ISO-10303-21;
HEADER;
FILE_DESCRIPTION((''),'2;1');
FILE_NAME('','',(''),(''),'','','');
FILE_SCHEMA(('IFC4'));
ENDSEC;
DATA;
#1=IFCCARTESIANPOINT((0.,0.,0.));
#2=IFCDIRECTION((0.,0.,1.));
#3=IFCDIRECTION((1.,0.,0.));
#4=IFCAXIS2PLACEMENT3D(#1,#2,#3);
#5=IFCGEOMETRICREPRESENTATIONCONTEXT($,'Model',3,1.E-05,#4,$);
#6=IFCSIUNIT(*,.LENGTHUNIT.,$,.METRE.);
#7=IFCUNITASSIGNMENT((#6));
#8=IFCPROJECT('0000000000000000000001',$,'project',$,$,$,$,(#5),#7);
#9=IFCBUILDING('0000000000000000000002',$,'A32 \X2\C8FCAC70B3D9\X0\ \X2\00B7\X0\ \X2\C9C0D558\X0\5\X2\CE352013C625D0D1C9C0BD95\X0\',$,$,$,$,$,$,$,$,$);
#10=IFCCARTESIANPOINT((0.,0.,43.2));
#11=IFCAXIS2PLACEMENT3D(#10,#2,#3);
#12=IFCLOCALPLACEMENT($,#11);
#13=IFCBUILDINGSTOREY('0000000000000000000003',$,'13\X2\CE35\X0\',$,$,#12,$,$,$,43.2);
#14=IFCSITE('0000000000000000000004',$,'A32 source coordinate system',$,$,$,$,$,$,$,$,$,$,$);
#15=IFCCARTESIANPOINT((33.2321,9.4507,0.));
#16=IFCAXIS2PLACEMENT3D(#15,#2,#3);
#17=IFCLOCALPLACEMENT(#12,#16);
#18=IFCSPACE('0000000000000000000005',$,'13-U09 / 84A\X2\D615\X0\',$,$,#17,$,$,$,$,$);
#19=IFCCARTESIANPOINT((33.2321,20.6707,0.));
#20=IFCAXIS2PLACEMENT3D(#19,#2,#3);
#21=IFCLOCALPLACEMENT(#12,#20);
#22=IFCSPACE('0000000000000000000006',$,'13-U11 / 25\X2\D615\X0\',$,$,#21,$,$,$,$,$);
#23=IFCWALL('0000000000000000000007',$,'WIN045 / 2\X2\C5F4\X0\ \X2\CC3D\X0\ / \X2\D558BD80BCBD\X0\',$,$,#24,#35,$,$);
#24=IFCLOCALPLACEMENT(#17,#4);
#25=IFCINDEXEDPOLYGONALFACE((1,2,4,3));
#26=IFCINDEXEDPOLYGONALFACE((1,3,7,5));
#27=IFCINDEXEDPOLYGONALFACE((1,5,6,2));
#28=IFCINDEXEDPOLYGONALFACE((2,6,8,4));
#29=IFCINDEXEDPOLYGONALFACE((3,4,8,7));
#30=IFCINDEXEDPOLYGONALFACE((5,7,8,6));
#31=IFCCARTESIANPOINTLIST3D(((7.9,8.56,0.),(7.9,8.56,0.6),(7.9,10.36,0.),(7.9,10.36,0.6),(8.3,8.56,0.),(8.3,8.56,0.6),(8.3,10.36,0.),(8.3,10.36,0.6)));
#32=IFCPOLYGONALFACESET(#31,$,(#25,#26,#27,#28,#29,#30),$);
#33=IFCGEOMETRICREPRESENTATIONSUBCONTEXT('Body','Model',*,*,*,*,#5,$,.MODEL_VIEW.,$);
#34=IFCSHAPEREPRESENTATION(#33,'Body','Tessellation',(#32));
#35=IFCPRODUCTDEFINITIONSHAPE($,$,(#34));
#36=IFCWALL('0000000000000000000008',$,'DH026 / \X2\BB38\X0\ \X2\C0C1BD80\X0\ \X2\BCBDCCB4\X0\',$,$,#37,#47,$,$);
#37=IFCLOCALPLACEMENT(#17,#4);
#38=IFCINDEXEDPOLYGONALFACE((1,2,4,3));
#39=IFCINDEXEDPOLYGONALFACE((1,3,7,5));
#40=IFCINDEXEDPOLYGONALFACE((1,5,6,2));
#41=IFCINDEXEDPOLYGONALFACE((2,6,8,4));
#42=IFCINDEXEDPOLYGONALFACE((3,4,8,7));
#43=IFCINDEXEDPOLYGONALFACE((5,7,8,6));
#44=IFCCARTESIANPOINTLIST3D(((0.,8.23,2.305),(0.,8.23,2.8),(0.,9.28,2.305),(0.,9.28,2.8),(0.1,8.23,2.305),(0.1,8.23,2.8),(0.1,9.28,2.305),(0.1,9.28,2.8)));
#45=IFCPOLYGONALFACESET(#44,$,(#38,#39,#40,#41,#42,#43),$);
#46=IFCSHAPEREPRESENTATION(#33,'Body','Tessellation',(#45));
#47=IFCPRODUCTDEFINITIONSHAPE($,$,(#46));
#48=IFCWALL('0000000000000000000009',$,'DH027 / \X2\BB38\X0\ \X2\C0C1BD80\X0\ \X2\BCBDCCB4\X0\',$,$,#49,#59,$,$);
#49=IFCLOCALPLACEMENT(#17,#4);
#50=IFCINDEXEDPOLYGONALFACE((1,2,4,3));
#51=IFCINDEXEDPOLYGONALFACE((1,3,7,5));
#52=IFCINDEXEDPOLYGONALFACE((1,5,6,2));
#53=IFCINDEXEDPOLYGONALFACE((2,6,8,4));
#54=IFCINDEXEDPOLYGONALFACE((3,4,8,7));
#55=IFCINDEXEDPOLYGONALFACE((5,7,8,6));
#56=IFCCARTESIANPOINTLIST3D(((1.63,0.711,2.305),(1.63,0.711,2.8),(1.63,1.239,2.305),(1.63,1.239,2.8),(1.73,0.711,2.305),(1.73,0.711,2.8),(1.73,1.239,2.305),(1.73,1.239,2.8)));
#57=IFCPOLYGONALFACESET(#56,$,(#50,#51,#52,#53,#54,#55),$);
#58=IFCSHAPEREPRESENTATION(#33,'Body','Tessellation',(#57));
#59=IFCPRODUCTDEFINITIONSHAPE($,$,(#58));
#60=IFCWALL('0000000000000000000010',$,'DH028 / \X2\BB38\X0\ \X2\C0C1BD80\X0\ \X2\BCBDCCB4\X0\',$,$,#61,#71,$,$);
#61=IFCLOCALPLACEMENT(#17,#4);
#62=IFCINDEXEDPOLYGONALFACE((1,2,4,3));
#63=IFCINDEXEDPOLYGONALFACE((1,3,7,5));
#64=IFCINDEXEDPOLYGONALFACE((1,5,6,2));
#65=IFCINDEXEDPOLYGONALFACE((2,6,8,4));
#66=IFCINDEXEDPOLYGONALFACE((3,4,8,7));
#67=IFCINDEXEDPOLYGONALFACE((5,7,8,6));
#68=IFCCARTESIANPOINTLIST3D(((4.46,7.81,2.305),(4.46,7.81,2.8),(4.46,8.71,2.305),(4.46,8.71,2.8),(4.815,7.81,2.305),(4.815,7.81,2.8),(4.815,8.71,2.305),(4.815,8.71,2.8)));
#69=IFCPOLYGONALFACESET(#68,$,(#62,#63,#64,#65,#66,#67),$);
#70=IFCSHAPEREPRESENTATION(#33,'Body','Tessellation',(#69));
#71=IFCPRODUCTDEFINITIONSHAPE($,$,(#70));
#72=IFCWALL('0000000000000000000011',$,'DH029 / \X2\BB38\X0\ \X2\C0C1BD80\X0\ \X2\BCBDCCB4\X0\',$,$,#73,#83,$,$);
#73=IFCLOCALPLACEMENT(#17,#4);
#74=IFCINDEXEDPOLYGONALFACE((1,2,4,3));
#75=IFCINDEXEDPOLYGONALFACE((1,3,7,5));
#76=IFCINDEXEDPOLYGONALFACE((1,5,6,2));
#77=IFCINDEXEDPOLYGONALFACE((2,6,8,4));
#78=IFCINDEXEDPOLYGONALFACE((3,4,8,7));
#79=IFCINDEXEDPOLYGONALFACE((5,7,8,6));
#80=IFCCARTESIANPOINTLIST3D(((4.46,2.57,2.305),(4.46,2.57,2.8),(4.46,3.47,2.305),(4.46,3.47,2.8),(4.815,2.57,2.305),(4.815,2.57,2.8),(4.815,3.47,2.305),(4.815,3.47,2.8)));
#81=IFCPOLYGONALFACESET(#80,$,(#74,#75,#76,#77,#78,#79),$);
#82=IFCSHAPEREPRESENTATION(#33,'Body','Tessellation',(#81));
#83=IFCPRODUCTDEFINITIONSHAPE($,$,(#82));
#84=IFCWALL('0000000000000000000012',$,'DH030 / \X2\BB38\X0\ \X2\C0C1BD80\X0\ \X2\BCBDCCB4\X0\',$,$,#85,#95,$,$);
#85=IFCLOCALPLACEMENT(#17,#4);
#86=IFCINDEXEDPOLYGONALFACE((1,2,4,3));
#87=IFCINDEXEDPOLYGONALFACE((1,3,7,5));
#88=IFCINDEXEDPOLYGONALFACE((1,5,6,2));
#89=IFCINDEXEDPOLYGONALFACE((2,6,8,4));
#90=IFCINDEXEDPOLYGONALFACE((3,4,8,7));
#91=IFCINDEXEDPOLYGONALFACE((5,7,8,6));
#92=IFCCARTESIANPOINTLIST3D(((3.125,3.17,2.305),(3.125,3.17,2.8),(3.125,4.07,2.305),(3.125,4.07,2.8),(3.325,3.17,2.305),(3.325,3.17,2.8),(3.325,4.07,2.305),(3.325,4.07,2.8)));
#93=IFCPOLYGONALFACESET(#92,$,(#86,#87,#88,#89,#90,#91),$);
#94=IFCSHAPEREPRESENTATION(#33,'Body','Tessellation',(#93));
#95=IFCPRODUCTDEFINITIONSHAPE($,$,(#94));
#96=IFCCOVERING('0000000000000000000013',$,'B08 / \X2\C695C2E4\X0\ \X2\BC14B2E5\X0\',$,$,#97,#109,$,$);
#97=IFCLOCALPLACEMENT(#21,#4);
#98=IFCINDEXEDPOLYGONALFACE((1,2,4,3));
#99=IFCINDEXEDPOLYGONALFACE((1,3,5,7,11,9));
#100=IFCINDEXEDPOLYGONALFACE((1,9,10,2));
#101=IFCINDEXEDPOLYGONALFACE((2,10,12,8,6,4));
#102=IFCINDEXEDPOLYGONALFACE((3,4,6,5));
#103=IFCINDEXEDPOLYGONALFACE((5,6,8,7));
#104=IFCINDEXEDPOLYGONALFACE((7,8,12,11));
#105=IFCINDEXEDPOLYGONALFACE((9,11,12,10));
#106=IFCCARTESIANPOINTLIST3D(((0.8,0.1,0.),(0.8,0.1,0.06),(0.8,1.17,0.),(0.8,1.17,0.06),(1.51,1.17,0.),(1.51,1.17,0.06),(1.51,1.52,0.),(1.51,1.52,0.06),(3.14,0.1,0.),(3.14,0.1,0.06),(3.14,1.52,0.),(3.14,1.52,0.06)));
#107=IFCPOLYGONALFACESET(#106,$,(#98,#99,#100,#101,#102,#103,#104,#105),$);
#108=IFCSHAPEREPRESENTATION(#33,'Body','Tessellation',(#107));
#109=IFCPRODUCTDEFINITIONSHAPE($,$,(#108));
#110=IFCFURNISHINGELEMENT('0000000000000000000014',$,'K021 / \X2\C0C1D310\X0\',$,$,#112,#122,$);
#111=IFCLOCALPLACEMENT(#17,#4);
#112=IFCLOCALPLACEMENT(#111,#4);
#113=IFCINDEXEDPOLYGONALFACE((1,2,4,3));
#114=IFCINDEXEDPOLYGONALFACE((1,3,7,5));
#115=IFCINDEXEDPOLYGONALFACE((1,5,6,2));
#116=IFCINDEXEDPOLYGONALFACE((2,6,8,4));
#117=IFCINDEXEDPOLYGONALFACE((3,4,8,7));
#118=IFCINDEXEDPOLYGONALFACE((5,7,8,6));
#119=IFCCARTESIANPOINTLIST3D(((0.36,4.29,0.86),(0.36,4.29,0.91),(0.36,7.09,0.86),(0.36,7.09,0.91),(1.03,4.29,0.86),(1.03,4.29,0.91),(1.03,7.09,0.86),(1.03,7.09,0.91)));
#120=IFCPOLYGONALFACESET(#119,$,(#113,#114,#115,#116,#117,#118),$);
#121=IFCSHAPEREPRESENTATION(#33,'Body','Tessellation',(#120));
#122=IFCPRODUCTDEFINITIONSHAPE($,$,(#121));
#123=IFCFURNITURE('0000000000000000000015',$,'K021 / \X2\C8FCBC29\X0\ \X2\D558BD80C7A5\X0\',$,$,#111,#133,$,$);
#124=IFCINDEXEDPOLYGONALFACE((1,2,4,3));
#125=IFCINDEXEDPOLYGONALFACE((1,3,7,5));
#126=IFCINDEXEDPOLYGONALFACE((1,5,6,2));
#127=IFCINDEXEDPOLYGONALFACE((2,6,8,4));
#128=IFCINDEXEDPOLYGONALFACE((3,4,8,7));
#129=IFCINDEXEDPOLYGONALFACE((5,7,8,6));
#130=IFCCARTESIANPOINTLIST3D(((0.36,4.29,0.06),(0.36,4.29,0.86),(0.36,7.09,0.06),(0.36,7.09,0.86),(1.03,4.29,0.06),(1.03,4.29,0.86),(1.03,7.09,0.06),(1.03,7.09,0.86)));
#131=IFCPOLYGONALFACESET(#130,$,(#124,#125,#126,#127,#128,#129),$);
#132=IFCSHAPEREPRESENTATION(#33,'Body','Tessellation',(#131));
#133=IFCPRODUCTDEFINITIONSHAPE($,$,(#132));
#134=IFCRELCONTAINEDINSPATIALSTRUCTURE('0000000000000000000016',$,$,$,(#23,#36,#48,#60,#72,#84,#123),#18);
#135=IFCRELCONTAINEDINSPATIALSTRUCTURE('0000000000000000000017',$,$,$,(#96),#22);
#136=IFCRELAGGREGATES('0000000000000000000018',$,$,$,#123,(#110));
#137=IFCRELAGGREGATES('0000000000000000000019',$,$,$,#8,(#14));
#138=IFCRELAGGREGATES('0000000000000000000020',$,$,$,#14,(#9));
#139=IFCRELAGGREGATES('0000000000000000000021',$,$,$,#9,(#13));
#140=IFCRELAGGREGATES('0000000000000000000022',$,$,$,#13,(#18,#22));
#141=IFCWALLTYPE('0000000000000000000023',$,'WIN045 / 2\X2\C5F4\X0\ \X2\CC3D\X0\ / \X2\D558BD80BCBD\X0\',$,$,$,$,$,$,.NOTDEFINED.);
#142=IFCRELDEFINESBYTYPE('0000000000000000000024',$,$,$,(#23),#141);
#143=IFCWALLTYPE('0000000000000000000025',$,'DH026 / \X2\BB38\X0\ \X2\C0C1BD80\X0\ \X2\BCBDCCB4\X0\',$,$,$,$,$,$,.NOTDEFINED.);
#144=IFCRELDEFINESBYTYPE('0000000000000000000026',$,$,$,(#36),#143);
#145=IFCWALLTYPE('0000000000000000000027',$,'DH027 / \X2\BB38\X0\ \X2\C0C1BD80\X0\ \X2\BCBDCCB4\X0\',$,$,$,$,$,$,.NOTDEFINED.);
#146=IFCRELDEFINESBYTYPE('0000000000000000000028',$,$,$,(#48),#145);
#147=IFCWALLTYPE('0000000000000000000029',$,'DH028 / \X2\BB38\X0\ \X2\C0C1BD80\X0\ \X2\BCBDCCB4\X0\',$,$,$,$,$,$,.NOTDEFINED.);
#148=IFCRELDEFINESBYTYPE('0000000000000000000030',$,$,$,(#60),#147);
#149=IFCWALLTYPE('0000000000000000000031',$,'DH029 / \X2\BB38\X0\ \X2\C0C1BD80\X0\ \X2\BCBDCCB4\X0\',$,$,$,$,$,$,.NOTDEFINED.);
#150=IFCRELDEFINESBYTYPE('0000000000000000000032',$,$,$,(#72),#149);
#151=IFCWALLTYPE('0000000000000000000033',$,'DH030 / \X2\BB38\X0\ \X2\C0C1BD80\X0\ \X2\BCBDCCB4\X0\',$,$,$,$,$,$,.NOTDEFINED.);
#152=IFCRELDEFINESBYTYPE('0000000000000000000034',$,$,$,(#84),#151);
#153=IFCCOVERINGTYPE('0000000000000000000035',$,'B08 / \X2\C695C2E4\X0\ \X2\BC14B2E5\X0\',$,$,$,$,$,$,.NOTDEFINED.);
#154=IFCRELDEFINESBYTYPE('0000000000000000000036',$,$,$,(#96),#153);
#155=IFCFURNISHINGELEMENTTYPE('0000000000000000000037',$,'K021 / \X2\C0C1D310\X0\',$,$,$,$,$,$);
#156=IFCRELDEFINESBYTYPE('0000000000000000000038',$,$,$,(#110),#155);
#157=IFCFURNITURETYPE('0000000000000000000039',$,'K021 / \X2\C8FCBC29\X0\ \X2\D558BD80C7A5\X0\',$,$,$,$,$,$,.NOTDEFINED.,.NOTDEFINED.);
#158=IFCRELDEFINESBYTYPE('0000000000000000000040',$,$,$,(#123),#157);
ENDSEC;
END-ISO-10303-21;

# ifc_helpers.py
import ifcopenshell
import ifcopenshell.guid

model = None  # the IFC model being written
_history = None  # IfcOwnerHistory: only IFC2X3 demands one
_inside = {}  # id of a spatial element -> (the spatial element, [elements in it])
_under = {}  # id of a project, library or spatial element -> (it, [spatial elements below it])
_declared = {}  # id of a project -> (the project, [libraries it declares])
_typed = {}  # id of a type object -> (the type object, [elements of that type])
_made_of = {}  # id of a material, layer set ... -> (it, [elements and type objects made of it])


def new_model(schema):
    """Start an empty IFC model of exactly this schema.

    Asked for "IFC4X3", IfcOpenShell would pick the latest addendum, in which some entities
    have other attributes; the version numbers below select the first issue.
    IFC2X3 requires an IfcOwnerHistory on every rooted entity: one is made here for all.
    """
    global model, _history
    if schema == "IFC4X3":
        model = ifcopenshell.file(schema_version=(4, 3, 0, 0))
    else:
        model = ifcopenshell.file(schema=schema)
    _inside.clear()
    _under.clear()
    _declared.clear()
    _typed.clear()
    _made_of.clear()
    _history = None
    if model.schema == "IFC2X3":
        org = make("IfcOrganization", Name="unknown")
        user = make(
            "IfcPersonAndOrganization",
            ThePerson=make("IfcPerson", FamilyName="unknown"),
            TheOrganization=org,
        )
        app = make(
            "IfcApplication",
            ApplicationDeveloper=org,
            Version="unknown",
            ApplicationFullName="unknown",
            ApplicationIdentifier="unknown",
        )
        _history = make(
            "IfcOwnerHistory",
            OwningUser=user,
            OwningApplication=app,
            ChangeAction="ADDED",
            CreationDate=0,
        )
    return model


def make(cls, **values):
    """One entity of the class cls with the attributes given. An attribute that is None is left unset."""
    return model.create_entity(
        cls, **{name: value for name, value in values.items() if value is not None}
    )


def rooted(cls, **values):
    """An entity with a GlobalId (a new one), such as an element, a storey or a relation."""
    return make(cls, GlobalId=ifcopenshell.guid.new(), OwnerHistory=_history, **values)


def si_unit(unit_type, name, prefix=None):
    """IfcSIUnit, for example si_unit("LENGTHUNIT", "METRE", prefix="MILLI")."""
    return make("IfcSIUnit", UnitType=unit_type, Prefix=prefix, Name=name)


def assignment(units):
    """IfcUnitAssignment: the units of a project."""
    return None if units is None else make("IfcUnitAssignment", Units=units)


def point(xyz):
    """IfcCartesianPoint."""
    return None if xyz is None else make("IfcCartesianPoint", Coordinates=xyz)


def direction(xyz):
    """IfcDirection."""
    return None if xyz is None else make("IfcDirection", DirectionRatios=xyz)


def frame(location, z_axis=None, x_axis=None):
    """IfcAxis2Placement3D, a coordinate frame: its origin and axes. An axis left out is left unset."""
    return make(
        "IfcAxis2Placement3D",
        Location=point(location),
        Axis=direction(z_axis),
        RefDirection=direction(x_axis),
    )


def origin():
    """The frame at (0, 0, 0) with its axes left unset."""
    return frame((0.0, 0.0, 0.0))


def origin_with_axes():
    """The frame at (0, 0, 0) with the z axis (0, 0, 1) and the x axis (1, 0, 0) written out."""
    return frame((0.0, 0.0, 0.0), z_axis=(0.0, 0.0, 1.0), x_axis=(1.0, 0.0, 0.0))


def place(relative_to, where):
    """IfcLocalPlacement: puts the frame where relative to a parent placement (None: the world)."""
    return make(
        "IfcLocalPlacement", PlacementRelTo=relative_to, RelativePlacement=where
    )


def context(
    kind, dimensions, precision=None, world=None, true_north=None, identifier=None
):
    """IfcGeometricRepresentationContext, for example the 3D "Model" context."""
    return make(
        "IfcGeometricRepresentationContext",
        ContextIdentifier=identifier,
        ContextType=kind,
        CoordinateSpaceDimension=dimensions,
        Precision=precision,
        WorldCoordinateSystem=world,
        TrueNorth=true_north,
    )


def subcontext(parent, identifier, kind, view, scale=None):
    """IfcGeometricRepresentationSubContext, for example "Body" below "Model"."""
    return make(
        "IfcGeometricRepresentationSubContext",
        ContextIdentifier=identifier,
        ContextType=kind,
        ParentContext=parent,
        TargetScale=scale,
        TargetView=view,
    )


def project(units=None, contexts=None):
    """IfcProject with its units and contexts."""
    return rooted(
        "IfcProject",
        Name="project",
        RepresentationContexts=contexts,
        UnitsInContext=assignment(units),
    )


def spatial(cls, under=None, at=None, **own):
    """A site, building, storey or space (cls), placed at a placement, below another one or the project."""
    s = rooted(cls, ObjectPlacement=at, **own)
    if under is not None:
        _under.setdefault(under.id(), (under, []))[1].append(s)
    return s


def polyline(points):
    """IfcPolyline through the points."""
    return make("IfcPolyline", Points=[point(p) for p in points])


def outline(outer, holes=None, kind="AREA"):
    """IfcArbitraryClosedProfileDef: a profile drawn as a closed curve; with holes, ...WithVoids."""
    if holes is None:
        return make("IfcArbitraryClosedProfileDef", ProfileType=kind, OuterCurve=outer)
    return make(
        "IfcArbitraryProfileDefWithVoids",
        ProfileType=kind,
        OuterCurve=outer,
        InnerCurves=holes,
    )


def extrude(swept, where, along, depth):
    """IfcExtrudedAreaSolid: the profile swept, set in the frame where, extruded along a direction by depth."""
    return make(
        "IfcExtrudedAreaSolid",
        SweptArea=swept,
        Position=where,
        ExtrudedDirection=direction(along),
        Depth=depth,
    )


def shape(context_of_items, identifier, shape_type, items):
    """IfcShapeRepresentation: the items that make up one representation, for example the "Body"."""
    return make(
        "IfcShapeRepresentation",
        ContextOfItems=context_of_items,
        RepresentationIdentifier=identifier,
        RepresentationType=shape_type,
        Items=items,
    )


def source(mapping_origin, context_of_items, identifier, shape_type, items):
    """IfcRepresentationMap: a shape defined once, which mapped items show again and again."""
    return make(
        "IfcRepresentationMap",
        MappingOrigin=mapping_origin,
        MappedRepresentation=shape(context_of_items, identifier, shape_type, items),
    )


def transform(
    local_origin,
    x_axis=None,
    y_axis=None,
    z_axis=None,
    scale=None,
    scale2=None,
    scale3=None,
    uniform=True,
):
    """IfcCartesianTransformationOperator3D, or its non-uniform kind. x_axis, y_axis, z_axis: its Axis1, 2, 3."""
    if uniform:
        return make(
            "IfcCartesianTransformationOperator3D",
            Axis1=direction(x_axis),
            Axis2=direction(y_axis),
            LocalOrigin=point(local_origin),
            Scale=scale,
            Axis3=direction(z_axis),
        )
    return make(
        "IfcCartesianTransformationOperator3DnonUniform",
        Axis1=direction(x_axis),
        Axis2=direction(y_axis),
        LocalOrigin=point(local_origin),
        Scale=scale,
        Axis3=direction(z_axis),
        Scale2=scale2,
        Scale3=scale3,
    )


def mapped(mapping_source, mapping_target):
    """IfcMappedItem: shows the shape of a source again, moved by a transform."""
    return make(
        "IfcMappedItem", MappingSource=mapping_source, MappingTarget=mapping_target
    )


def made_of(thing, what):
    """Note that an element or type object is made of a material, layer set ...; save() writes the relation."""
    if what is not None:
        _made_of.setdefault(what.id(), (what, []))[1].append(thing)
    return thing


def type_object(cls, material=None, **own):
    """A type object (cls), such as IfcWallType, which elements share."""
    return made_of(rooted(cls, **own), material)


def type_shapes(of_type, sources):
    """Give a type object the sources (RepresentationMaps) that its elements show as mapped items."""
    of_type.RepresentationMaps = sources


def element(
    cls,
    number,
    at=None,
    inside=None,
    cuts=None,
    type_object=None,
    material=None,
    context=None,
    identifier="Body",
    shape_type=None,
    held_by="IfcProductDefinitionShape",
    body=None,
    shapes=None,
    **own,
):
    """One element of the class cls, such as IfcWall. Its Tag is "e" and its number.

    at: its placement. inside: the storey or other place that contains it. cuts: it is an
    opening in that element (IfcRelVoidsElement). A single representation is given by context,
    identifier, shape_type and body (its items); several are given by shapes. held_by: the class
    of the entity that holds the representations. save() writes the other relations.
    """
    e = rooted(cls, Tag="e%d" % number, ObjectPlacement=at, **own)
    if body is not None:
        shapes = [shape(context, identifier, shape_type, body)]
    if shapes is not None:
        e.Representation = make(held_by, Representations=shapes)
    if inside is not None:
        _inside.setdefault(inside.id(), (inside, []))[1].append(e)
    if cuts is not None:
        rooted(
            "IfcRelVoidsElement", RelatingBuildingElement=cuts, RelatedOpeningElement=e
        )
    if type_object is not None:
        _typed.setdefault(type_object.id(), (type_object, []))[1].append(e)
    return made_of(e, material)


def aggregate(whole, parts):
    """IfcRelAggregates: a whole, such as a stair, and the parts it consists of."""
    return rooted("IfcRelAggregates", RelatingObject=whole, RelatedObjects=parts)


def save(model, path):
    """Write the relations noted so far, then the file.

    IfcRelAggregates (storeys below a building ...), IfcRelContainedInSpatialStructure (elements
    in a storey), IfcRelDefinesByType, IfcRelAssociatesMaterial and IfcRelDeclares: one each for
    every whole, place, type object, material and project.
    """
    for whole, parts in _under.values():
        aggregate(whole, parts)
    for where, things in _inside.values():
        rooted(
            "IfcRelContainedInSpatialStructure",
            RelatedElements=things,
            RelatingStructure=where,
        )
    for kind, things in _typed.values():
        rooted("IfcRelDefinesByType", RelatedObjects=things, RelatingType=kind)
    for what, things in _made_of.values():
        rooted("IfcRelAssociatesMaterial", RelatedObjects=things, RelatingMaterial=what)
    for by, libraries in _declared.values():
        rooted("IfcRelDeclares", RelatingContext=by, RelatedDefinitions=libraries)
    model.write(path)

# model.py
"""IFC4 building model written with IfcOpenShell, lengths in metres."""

from ifc_helpers import new_model, si_unit, frame, origin, origin_with_axes, place, context, subcontext, project, spatial, polyline, outline, extrude, source, transform, mapped, type_object, type_shapes, element, aggregate, save


model = new_model("IFC4")

# Units and contexts
model_context = context("Model", 3, precision=1e-05, world=origin_with_axes())
body_context = subcontext(model_context, "Body", "Model", "MODEL_VIEW")
ifc_project = project(units=[si_unit("LENGTHUNIT", "METRE")], contexts=[model_context])

# Site, building, storey, space
site = spatial("IfcSite", under=ifc_project, Name="A32 source coordinate system")
building = spatial("IfcBuilding", under=site, Name="A32 주거동 · 지하5층–옥탑지붕")
storey_placement = place(None, frame((0.0, 0.0, 43.2), z_axis=(0.0, 0.0, 1.0), x_axis=(1.0, 0.0, 0.0)))
storey = spatial("IfcBuildingStorey", under=building, at=storey_placement, Name="13층", Elevation=43.2)
space_1_placement = place(storey_placement, frame((33.2321, 9.4507, 0.0), z_axis=(0.0, 0.0, 1.0), x_axis=(1.0, 0.0, 0.0)))
space_1 = spatial("IfcSpace", under=storey, at=space_1_placement, Name="13-U09 / 84A형")

# Walls
wall_type_1 = type_object("IfcWallType", Name="WIN045 / 2열 창 / 하부벽", PredefinedType="NOTDEFINED")
shared_shape_1 = source(origin(), body_context, "Body", "SweptSolid", [
    extrude(outline(polyline([(7.9, 10.36), (8.3, 10.36), (8.3, 8.56), (7.9, 8.56), (7.9, 10.36)])), origin(), (0.0, 0.0, 1.0), 0.6),
])
type_shapes(wall_type_1, [shared_shape_1])
wall_1_placement = place(space_1_placement, origin_with_axes())
element("IfcWall", 1, at=wall_1_placement, inside=space_1, type_object=wall_type_1, Name="WIN045 / 2열 창 / 하부벽", context=body_context, shape_type="MappedRepresentation", body=[
    mapped(shared_shape_1, transform((0.0, 0.0, 0.0), scale=1.0)),
])
wall_type_2 = type_object("IfcWallType", Name="DH026 / 문 상부 벽체", PredefinedType="NOTDEFINED")
shared_shape_2 = source(origin(), body_context, "Body", "SweptSolid", [
    extrude(outline(polyline([(0.1, 9.28), (0.1, 8.23), (0.0, 8.23), (0.0, 9.28), (0.1, 9.28)])), frame((0.0, 0.0, 2.305)), (0.0, 0.0, 1.0), 0.495),
])
type_shapes(wall_type_2, [shared_shape_2])
wall_2_placement = place(space_1_placement, origin_with_axes())
element("IfcWall", 2, at=wall_2_placement, inside=space_1, type_object=wall_type_2, Name="DH026 / 문 상부 벽체", context=body_context, shape_type="MappedRepresentation", body=[
    mapped(shared_shape_2, transform((0.0, 0.0, 0.0), scale=1.0)),
])
wall_type_3 = type_object("IfcWallType", Name="DH027 / 문 상부 벽체", PredefinedType="NOTDEFINED")
shared_shape_3 = source(origin(), body_context, "Body", "SweptSolid", [
    extrude(outline(polyline([(1.63, 1.239), (1.73, 1.239), (1.73, 0.711), (1.63, 0.711), (1.63, 1.239)])), frame((0.0, 0.0, 2.305)), (0.0, 0.0, 1.0), 0.495),
])
type_shapes(wall_type_3, [shared_shape_3])
wall_3_placement = place(space_1_placement, origin_with_axes())
element("IfcWall", 3, at=wall_3_placement, inside=space_1, type_object=wall_type_3, Name="DH027 / 문 상부 벽체", context=body_context, shape_type="MappedRepresentation", body=[
    mapped(shared_shape_3, transform((0.0, 0.0, 0.0), scale=1.0)),
])
wall_type_4 = type_object("IfcWallType", Name="DH028 / 문 상부 벽체", PredefinedType="NOTDEFINED")
shared_shape_4 = source(origin(), body_context, "Body", "SweptSolid", [
    extrude(outline(polyline([(4.815, 8.71), (4.815, 7.81), (4.46, 7.81), (4.46, 8.71), (4.815, 8.71)])), frame((0.0, 0.0, 2.305)), (0.0, 0.0, 1.0), 0.495),
])
type_shapes(wall_type_4, [shared_shape_4])
wall_4_placement = place(space_1_placement, origin_with_axes())
element("IfcWall", 4, at=wall_4_placement, inside=space_1, type_object=wall_type_4, Name="DH028 / 문 상부 벽체", context=body_context, shape_type="MappedRepresentation", body=[
    mapped(shared_shape_4, transform((0.0, 0.0, 0.0), scale=1.0)),
])
wall_type_5 = type_object("IfcWallType", Name="DH029 / 문 상부 벽체", PredefinedType="NOTDEFINED")
shared_shape_5 = source(origin(), body_context, "Body", "SweptSolid", [
    extrude(outline(polyline([(4.815, 3.47), (4.815, 2.57), (4.46, 2.57), (4.46, 3.47), (4.815, 3.47)])), frame((0.0, 0.0, 2.305)), (0.0, 0.0, 1.0), 0.495),
])
type_shapes(wall_type_5, [shared_shape_5])
wall_5_placement = place(space_1_placement, origin_with_axes())
element("IfcWall", 5, at=wall_5_placement, inside=space_1, type_object=wall_type_5, Name="DH029 / 문 상부 벽체", context=body_context, shape_type="MappedRepresentation", body=[
    mapped(shared_shape_5, transform((0.0, 0.0, 0.0), scale=1.0)),
])
wall_type_6 = type_object("IfcWallType", Name="DH030 / 문 상부 벽체", PredefinedType="NOTDEFINED")
shared_shape_6 = source(origin(), body_context, "Body", "SweptSolid", [
    extrude(outline(polyline([(3.325, 4.07), (3.325, 3.17), (3.125, 3.17), (3.125, 4.07), (3.325, 4.07)])), frame((0.0, 0.0, 2.305)), (0.0, 0.0, 1.0), 0.495),
])
type_shapes(wall_type_6, [shared_shape_6])
wall_6_placement = place(space_1_placement, origin_with_axes())
element("IfcWall", 6, at=wall_6_placement, inside=space_1, type_object=wall_type_6, Name="DH030 / 문 상부 벽체", context=body_context, shape_type="MappedRepresentation", body=[
    mapped(shared_shape_6, transform((0.0, 0.0, 0.0), scale=1.0)),
])

# Shared definitions
space_2_placement = place(storey_placement, frame((33.2321, 20.6707, 0.0), z_axis=(0.0, 0.0, 1.0), x_axis=(1.0, 0.0, 0.0)))
space_2 = spatial("IfcSpace", under=storey, at=space_2_placement, Name="13-U11 / 25형")

# Covering
covering_type_1 = type_object("IfcCoveringType", Name="B08 / 욕실 바닥", PredefinedType="NOTDEFINED")
shared_shape_7 = source(origin(), body_context, "Body", "SweptSolid", [
    extrude(outline(polyline([(3.14, 0.1), (0.8, 0.1), (0.8, 1.17), (1.51, 1.17), (1.51, 1.52), (3.14, 1.52), (3.14, 0.1)])), origin(), (0.0, 0.0, 1.0), 0.06),
])
type_shapes(covering_type_1, [shared_shape_7])
covering_1_placement = place(space_2_placement, origin_with_axes())
element("IfcCovering", 7, at=covering_1_placement, inside=space_2, type_object=covering_type_1, Name="B08 / 욕실 바닥", context=body_context, shape_type="MappedRepresentation", body=[
    mapped(shared_shape_7, transform((0.0, 0.0, 0.0), scale=1.0)),
])

# Furnishing element
furnishing_element_type = type_object("IfcFurnishingElementType", Name="K021 / 상판")
shared_shape_8 = source(origin(), body_context, "Body", "SweptSolid", [
    extrude(outline(polyline([(0.36, 7.09), (1.03, 7.09), (1.03, 4.29), (0.36, 4.29), (0.36, 7.09)])), frame((0.0, 0.0, 0.86)), (0.0, 0.0, 1.0), 0.05),
])
type_shapes(furnishing_element_type, [shared_shape_8])
furniture_placement = place(space_1_placement, origin_with_axes())
furnishing_placement = place(furniture_placement, origin_with_axes())
furnishing = element("IfcFurnishingElement", 8, at=furnishing_placement, type_object=furnishing_element_type, Name="K021 / 상판", context=body_context, shape_type="MappedRepresentation", body=[
    mapped(shared_shape_8, transform((0.0, 0.0, 0.0), scale=1.0)),
])

# Furniture
furniture_type = type_object("IfcFurnitureType", Name="K021 / 주방 하부장", AssemblyPlace="NOTDEFINED", PredefinedType="NOTDEFINED")
shared_shape_9 = source(origin(), body_context, "Body", "SweptSolid", [
    extrude(outline(polyline([(0.36, 4.29), (0.36, 7.09), (1.03, 7.09), (1.03, 4.29), (0.36, 4.29)])), frame((0.0, 0.0, 0.06)), (0.0, 0.0, 1.0), 0.8),
])
type_shapes(furniture_type, [shared_shape_9])
furniture = element("IfcFurniture", 9, at=furniture_placement, inside=space_1, type_object=furniture_type, Name="K021 / 주방 하부장", context=body_context, shape_type="MappedRepresentation", body=[
    mapped(shared_shape_9, transform((0.0, 0.0, 0.0), scale=1.0)),
])
aggregate(furniture, [furnishing])

save(model, "model.ifc")
